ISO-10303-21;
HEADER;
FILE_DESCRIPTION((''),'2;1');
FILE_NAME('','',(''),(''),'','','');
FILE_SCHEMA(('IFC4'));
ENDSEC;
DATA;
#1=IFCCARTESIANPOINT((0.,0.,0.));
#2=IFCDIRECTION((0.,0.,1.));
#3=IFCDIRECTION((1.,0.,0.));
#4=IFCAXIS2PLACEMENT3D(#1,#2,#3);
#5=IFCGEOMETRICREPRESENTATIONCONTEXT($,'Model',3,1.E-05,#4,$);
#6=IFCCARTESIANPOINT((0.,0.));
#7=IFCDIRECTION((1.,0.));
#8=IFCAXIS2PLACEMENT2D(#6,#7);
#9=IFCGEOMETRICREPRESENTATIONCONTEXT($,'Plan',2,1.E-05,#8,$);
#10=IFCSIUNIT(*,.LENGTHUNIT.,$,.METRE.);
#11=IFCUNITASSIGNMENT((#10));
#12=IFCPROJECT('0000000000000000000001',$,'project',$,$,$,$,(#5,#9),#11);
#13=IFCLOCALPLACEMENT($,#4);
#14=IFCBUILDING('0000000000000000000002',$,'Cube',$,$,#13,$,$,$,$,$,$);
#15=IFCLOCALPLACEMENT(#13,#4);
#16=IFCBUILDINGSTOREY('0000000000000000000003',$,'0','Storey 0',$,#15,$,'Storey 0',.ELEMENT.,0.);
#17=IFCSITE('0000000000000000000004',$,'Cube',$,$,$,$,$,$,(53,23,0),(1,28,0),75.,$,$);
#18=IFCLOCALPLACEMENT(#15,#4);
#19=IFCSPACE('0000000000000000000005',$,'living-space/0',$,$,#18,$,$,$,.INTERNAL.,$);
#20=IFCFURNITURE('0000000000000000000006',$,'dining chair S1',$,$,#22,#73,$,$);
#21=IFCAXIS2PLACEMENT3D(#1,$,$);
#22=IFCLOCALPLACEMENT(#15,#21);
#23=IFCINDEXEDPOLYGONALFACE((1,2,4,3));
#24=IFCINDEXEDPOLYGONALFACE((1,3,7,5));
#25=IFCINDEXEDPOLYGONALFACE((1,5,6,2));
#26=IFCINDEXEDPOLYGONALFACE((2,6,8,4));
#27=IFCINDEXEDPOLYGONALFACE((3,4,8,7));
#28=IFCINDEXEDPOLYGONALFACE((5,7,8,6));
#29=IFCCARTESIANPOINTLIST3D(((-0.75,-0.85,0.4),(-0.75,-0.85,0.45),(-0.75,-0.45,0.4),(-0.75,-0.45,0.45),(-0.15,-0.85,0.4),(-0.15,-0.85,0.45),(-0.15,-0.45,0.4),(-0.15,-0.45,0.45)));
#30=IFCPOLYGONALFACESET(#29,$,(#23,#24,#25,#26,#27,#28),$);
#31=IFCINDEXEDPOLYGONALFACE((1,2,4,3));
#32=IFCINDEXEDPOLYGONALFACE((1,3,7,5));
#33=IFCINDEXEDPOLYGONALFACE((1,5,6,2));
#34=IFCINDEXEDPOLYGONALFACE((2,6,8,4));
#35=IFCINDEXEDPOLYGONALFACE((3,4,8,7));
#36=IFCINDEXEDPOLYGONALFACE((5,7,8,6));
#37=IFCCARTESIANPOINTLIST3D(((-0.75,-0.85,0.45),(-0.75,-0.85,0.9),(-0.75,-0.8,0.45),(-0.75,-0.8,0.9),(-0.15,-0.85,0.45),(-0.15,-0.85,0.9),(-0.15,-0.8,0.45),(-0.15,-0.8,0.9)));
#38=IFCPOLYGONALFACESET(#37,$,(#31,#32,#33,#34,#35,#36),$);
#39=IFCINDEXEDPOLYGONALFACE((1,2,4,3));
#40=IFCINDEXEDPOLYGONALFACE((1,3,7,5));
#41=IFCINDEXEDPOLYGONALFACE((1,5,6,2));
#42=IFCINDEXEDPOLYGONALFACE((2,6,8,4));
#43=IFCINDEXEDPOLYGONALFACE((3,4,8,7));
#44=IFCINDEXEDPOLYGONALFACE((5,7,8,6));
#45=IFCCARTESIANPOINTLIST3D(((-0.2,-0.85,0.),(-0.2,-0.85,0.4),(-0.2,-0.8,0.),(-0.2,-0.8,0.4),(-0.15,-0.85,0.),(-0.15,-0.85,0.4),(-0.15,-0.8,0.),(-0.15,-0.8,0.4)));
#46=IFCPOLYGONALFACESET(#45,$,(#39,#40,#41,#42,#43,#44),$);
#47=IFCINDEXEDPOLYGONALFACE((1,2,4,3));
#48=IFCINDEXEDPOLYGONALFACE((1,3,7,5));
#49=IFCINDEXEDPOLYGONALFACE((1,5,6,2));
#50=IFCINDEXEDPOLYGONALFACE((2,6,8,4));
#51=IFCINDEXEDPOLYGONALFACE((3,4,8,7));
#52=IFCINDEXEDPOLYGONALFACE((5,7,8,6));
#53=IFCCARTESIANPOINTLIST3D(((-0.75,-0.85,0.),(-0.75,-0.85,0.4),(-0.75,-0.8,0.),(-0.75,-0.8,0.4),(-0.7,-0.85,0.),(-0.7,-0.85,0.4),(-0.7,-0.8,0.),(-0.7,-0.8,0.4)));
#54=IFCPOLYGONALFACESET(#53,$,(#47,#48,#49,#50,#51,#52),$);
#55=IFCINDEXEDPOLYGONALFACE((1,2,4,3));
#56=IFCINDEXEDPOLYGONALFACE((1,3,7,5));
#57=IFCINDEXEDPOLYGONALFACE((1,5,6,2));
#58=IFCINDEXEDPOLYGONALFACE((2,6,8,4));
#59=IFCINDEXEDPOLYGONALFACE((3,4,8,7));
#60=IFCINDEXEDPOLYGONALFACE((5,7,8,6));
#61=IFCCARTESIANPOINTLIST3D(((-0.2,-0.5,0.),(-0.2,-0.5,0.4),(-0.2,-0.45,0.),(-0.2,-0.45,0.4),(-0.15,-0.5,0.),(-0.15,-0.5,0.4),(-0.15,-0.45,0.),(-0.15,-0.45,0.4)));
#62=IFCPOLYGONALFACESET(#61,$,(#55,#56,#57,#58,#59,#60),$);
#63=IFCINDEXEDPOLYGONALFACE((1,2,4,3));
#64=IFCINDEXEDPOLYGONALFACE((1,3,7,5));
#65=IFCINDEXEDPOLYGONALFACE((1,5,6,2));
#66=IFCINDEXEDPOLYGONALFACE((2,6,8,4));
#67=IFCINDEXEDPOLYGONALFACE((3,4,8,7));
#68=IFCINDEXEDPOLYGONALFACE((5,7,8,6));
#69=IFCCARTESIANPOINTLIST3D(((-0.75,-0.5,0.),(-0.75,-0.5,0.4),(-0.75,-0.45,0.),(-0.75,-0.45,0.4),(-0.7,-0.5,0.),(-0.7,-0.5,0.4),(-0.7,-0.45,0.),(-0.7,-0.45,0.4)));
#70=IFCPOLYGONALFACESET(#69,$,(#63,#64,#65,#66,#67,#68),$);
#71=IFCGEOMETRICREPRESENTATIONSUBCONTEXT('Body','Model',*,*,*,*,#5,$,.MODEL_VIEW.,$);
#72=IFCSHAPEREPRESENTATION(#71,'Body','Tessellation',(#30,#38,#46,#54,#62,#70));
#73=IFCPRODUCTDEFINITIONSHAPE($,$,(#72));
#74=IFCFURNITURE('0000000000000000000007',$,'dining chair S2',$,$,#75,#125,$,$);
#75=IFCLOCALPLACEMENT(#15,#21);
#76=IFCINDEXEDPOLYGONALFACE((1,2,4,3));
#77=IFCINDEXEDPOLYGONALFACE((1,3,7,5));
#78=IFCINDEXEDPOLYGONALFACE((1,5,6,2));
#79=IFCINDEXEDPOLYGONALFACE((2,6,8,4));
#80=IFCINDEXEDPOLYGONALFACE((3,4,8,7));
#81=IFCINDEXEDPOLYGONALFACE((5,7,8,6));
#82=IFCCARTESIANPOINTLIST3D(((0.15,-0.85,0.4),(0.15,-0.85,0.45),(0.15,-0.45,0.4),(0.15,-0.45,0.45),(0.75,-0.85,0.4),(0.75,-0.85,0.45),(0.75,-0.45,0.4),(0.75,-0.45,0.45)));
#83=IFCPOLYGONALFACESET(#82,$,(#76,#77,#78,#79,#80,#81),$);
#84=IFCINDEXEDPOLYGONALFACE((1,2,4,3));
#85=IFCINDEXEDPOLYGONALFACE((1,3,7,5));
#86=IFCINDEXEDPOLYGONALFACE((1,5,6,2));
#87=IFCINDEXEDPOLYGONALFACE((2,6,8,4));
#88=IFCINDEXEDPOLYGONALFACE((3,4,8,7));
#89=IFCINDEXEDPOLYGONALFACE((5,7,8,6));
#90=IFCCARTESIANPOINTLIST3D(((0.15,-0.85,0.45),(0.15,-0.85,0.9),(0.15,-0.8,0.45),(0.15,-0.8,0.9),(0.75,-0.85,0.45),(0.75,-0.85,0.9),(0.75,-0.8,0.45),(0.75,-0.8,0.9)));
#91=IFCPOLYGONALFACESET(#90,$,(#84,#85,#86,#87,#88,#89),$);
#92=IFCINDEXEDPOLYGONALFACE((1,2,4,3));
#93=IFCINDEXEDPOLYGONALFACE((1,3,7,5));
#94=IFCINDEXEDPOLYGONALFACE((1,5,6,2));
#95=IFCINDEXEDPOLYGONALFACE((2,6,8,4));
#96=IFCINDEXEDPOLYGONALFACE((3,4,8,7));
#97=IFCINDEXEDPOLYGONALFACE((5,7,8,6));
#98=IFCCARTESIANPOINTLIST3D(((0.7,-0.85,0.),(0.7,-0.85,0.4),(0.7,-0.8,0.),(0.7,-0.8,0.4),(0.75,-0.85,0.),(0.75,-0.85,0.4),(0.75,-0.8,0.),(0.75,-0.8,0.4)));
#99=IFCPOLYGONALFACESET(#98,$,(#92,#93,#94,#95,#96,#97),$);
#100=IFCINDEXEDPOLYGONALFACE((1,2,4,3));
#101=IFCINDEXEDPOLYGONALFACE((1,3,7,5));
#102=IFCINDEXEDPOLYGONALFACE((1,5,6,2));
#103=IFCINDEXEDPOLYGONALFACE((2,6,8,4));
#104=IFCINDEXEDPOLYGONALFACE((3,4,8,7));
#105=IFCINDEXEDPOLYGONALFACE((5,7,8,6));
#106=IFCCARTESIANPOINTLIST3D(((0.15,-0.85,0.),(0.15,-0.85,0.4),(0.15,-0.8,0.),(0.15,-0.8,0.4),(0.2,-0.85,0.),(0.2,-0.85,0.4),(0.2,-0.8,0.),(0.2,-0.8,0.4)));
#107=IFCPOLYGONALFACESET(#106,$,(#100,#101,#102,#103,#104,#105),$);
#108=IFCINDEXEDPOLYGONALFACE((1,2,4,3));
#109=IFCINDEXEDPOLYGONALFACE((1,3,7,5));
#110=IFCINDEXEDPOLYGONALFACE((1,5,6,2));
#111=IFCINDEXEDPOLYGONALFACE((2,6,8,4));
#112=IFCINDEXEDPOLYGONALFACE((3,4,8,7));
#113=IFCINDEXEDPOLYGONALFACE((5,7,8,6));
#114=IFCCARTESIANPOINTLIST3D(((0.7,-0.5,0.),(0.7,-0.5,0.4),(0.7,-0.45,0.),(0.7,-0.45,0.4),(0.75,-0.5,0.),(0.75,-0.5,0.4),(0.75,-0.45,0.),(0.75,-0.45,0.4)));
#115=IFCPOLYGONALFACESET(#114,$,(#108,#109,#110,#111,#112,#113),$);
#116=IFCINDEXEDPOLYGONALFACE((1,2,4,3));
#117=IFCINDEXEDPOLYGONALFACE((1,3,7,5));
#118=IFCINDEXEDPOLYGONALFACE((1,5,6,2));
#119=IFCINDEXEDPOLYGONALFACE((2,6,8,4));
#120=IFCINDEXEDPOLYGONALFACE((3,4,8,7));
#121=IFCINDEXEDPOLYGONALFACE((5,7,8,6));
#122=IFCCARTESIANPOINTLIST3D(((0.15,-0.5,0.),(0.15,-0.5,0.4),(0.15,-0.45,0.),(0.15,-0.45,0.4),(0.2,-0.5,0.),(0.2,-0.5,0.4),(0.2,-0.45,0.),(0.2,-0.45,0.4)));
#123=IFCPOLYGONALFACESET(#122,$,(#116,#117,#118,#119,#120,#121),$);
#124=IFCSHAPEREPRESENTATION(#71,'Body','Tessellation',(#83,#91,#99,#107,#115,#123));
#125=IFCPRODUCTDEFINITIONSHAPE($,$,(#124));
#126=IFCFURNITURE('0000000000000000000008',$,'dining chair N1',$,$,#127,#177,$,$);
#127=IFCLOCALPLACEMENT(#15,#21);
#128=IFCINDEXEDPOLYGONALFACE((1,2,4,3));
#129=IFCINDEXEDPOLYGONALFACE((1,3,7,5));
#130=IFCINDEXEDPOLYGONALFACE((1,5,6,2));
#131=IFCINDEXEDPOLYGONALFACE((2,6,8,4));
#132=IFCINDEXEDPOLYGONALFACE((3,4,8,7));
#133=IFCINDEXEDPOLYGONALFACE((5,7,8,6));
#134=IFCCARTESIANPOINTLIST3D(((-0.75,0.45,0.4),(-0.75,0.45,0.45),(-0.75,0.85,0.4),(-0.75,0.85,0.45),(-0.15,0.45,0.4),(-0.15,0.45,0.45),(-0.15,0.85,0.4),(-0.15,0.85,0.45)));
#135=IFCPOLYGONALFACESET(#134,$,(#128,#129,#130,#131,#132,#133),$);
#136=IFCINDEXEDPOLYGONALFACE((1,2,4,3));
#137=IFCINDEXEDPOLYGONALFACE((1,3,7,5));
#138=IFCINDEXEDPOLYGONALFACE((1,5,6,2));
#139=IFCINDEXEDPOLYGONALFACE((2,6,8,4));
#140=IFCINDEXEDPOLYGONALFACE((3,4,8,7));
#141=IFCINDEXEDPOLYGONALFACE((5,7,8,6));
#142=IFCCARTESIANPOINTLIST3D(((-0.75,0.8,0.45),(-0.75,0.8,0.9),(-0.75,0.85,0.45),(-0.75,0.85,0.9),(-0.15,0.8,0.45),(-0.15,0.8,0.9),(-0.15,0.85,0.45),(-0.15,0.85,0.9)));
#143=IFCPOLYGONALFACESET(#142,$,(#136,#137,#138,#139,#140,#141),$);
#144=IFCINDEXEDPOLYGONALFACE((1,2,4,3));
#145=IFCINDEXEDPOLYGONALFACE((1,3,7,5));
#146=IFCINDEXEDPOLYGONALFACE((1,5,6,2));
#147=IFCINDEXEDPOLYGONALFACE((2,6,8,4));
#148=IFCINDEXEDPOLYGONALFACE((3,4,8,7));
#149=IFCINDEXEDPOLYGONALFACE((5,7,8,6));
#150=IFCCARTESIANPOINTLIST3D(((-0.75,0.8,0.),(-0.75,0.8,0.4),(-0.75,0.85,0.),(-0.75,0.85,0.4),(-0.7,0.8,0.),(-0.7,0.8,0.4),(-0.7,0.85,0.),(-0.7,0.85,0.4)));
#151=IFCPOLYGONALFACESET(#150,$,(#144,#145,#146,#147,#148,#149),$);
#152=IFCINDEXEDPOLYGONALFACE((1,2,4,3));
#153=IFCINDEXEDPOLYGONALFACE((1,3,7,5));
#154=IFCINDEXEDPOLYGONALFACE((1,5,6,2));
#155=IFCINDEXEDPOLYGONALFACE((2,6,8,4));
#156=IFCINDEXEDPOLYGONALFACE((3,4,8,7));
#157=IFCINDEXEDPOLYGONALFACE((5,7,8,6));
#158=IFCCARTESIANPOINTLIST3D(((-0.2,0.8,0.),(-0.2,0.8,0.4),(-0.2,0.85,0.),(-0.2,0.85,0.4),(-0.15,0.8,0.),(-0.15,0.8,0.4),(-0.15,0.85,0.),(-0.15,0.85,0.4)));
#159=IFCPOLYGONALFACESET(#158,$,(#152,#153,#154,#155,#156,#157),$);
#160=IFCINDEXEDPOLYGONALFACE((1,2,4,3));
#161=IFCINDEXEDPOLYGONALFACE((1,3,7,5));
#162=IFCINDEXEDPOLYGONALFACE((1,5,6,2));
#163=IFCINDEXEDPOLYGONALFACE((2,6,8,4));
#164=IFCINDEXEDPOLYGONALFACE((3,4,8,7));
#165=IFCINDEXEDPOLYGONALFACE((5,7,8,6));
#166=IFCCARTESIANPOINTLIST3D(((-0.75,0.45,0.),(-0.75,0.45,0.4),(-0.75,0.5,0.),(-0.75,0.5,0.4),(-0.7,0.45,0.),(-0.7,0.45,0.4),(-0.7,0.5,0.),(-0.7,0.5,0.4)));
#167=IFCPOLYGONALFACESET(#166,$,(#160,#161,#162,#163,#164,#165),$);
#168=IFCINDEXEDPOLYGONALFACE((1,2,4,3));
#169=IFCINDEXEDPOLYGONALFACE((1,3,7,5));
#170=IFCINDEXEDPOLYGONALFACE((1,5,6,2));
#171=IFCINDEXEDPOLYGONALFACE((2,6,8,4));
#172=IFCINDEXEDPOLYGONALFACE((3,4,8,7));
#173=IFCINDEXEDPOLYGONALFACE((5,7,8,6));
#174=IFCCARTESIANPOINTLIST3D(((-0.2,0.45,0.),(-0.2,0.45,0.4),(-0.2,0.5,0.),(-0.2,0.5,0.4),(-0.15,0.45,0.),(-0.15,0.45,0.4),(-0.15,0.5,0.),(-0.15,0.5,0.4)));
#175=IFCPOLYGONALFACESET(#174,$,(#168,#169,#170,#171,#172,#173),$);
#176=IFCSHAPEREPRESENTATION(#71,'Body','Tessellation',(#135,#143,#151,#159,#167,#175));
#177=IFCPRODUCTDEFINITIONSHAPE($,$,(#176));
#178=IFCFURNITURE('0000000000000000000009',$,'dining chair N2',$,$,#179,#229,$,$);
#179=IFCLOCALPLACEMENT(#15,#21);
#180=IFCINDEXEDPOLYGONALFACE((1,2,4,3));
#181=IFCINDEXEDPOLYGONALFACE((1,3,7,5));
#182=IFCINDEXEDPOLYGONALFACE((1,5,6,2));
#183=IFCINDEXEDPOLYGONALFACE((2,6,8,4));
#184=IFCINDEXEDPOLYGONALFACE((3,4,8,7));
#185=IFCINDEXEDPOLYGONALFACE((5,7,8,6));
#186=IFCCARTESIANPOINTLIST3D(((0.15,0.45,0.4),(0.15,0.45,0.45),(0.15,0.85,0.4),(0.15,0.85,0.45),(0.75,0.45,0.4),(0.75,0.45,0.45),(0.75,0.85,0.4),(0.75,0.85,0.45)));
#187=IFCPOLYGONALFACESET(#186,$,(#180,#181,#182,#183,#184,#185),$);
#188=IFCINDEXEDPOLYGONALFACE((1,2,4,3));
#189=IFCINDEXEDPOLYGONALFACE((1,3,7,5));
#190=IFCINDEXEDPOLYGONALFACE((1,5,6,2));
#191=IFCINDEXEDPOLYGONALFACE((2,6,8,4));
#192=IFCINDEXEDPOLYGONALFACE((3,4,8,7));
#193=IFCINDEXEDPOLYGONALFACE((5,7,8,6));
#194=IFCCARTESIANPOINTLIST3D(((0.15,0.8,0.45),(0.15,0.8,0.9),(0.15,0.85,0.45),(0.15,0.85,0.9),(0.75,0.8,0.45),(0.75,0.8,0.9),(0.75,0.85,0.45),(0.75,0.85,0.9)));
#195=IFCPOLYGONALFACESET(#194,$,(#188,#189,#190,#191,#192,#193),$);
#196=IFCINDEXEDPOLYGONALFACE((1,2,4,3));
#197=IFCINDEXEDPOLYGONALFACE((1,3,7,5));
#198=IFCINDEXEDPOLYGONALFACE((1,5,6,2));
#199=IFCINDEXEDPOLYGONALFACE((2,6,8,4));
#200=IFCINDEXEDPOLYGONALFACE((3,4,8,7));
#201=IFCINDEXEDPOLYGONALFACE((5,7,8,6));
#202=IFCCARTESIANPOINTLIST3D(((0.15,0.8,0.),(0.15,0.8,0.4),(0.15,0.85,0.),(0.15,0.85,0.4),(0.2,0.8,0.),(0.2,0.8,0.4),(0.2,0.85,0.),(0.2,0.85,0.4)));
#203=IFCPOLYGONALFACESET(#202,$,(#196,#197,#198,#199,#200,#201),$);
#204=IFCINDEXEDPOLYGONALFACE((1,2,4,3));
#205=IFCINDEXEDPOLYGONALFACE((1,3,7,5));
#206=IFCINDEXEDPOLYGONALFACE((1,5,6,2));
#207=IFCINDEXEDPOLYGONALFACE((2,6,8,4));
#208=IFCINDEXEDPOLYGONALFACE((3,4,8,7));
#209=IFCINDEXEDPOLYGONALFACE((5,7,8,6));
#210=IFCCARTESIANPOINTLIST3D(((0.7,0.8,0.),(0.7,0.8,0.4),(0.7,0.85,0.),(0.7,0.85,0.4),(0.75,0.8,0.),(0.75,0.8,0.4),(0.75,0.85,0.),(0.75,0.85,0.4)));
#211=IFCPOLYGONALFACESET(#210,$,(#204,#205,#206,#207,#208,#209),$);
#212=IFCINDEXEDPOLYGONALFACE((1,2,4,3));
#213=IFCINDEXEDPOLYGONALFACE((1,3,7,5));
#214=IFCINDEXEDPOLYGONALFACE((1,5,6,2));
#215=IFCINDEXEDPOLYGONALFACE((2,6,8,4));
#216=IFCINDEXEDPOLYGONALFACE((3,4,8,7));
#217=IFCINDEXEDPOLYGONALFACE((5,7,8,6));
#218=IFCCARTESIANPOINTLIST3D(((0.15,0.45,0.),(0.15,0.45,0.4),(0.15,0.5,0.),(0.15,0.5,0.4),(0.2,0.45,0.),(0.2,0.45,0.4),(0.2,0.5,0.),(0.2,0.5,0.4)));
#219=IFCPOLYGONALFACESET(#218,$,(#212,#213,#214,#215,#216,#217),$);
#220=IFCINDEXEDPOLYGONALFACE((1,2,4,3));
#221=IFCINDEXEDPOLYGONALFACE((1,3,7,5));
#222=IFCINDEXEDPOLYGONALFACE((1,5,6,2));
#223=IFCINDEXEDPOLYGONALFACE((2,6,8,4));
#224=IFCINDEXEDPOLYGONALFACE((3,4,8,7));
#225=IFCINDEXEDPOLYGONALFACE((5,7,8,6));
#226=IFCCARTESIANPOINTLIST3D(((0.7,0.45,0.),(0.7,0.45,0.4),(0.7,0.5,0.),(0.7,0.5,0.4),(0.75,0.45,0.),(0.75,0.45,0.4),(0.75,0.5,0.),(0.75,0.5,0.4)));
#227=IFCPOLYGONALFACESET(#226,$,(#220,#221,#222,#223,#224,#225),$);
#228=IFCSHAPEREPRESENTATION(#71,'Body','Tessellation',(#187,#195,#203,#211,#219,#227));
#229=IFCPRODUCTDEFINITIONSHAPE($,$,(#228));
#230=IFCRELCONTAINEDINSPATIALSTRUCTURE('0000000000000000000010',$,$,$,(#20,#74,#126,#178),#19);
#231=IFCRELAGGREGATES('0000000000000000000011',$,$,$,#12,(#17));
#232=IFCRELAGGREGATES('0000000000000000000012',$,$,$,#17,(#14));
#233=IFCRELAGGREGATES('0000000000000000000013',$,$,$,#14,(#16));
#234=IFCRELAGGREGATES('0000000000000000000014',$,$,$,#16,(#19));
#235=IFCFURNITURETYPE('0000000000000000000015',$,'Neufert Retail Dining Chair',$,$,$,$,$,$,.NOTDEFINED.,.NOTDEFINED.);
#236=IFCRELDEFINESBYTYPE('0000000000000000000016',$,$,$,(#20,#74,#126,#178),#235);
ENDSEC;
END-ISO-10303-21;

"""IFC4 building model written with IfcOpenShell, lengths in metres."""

from ifc_helpers import new_model, entity, si_unit, frame, origin_with_axes, origin_2d_with_axis, place, context, subcontext, project, spatial, line, indexed_curve, outline, extrude, shape, source, transform, mapped, type_object, type_shapes, element, save


model = new_model("IFC4")

# Units and contexts
model_context = context("Model", 3, precision=1e-05, world=origin_with_axes())
plan_context = context("Plan", 2, precision=1e-05, world=origin_2d_with_axis())
body_context_1 = subcontext(model_context, "Body", "Model", "MODEL_VIEW")
body_context_2 = subcontext(plan_context, "Body", "Plan", "PLAN_VIEW")
ifc_project = project(units=[si_unit("LENGTHUNIT", "METRE")], contexts=[model_context, plan_context])

# Site, building, storey
site = spatial("IfcSite", under=ifc_project, Name="Cube", RefLatitude=(53, 23, 0), RefLongitude=(1, 28, 0), RefElevation=75.0)
building_placement = place(None, origin_with_axes())
building = spatial("IfcBuilding", under=site, at=building_placement, Name="Cube")
storey_placement = place(building_placement, origin_with_axes())
storey = spatial("IfcBuildingStorey", under=building, at=storey_placement, Name="0", Description="Storey 0", LongName="Storey 0", CompositionType="ELEMENT", Elevation=0.0)

# Shared definitions
space_placement = place(storey_placement, origin_with_axes())
space = spatial("IfcSpace", under=storey, at=space_placement, Name="living-space/0", PredefinedType="INTERNAL")

# Furniture
furniture_type_1 = type_object("IfcFurnitureType", Name="Neufert Retail Dining Chair", AssemblyPlace="NOTDEFINED", PredefinedType="NOTDEFINED")
shared_shape_1 = source(origin_with_axes(), body_context_1, "Body", "SweptSolid", [
    extrude(outline(indexed_curve([(-0.3, 0.0), (0.3, 0.0), (0.3, -0.4), (-0.3, -0.4)], segments=[line(1, 2, 3, 4, 1)])), frame((0.0, 0.0, 0.45), z_axis=(0.0, 0.0, 1.0), x_axis=(1.0, 0.0, 0.0)), (0.0, 0.0, -1.0), 0.05),
    extrude(outline(indexed_curve([(-0.3, 0.0), (0.3, 0.0), (0.3, -0.05), (-0.3, -0.05)], segments=[line(1, 2, 3, 4, 1)])), frame((0.0, 0.0, 0.9), z_axis=(0.0, 0.0, 1.0), x_axis=(1.0, 0.0, 0.0)), (0.0, 0.0, -1.0), 0.45),
    extrude(outline(indexed_curve([(-0.3, 0.0), (-0.25, 0.0), (-0.25, -0.05), (-0.3, -0.05)], segments=[line(1, 2, 3, 4, 1)])), origin_with_axes(), (0.0, 0.0, 1.0), 0.4),
    extrude(outline(indexed_curve([(0.3, 0.0), (0.25, 0.0), (0.25, -0.05), (0.3, -0.05)], segments=[line(1, 2, 3, 4, 1)])), origin_with_axes(), (0.0, 0.0, 1.0), 0.4),
    extrude(outline(indexed_curve([(-0.3, -0.4), (-0.25, -0.4), (-0.25, -0.35), (-0.3, -0.35)], segments=[line(1, 2, 3, 4, 1)])), origin_with_axes(), (0.0, 0.0, 1.0), 0.4),
    extrude(outline(indexed_curve([(0.3, -0.4), (0.25, -0.4), (0.25, -0.35), (0.3, -0.35)], segments=[line(1, 2, 3, 4, 1)])), origin_with_axes(), (0.0, 0.0, 1.0), 0.4),
])
shared_shape_2 = source(origin_with_axes(), body_context_2, "Body", "Curve2D", [
    entity("IfcIndexedPolyCurve", entity("IfcCartesianPointList2D", [[-0.3, -0.4], [0.3, -0.4]])),
    entity("IfcIndexedPolyCurve", entity("IfcCartesianPointList2D", [[-0.3, -0.4], [-0.3, -0.3], [-0.2121, -0.0879], [0.0, 0.0], [0.2121, -0.0879], [0.3, -0.3], [0.3, -0.4]]), [entity("IfcLineIndex", [1, 2]), entity("IfcArcIndex", [2, 3, 4]), entity("IfcArcIndex", [4, 5, 6]), entity("IfcLineIndex", [6, 7])]),
    entity("IfcIndexedPolyCurve", entity("IfcCartesianPointList2D", [[-0.26, -0.4], [-0.26, -0.3], [-0.1838, -0.1162], [0.0, -0.04], [0.1838, -0.1162], [0.26, -0.3], [0.26, -0.4]]), [entity("IfcLineIndex", [1, 2]), entity("IfcArcIndex", [2, 3, 4]), entity("IfcArcIndex", [4, 5, 6]), entity("IfcLineIndex", [6, 7])]),
])
type_shapes(furniture_type_1, [shared_shape_1, shared_shape_2])
for number, where, z_axis, x_axis, name in (
    (1, (-0.45, -0.85, 0.0), (0.0, 0.0, 1.0), (-1.0, 0.0, 0.0), "dining chair S1"),
    (2, (0.45, -0.85, 0.0), (0.0, 0.0, 1.0), (-1.0, 0.0, 0.0), "dining chair S2"),
    (3, (-0.45, 0.85, 0.0), (0.0, 0.0, 1.0), (1.0, 0.0, 0.0), "dining chair N1"),
    (4, (0.45, 0.85, 0.0), (0.0, 0.0, 1.0), (1.0, 0.0, 0.0), "dining chair N2"),
):
    element("IfcFurniture", number, at=place(space_placement, frame(where, z_axis=z_axis, x_axis=x_axis)), inside=space, type_object=furniture_type_1, Name=name, shapes=[
        shape(body_context_1, "Body", "MappedRepresentation", [mapped(shared_shape_1, transform((0.0, 0.0, 0.0), x_axis=(1.0, 0.0, 0.0), y_axis=(0.0, 1.0, 0.0), z_axis=(0.0, 0.0, 1.0), scale=1.0))]),
        shape(body_context_2, "Body", "MappedRepresentation", [mapped(shared_shape_2, transform((0.0, 0.0, 0.0), x_axis=(1.0, 0.0, 0.0), y_axis=(0.0, 1.0, 0.0), z_axis=(0.0, 0.0, 1.0), scale=1.0))]),
    ])

save(model, "model.ifc")
